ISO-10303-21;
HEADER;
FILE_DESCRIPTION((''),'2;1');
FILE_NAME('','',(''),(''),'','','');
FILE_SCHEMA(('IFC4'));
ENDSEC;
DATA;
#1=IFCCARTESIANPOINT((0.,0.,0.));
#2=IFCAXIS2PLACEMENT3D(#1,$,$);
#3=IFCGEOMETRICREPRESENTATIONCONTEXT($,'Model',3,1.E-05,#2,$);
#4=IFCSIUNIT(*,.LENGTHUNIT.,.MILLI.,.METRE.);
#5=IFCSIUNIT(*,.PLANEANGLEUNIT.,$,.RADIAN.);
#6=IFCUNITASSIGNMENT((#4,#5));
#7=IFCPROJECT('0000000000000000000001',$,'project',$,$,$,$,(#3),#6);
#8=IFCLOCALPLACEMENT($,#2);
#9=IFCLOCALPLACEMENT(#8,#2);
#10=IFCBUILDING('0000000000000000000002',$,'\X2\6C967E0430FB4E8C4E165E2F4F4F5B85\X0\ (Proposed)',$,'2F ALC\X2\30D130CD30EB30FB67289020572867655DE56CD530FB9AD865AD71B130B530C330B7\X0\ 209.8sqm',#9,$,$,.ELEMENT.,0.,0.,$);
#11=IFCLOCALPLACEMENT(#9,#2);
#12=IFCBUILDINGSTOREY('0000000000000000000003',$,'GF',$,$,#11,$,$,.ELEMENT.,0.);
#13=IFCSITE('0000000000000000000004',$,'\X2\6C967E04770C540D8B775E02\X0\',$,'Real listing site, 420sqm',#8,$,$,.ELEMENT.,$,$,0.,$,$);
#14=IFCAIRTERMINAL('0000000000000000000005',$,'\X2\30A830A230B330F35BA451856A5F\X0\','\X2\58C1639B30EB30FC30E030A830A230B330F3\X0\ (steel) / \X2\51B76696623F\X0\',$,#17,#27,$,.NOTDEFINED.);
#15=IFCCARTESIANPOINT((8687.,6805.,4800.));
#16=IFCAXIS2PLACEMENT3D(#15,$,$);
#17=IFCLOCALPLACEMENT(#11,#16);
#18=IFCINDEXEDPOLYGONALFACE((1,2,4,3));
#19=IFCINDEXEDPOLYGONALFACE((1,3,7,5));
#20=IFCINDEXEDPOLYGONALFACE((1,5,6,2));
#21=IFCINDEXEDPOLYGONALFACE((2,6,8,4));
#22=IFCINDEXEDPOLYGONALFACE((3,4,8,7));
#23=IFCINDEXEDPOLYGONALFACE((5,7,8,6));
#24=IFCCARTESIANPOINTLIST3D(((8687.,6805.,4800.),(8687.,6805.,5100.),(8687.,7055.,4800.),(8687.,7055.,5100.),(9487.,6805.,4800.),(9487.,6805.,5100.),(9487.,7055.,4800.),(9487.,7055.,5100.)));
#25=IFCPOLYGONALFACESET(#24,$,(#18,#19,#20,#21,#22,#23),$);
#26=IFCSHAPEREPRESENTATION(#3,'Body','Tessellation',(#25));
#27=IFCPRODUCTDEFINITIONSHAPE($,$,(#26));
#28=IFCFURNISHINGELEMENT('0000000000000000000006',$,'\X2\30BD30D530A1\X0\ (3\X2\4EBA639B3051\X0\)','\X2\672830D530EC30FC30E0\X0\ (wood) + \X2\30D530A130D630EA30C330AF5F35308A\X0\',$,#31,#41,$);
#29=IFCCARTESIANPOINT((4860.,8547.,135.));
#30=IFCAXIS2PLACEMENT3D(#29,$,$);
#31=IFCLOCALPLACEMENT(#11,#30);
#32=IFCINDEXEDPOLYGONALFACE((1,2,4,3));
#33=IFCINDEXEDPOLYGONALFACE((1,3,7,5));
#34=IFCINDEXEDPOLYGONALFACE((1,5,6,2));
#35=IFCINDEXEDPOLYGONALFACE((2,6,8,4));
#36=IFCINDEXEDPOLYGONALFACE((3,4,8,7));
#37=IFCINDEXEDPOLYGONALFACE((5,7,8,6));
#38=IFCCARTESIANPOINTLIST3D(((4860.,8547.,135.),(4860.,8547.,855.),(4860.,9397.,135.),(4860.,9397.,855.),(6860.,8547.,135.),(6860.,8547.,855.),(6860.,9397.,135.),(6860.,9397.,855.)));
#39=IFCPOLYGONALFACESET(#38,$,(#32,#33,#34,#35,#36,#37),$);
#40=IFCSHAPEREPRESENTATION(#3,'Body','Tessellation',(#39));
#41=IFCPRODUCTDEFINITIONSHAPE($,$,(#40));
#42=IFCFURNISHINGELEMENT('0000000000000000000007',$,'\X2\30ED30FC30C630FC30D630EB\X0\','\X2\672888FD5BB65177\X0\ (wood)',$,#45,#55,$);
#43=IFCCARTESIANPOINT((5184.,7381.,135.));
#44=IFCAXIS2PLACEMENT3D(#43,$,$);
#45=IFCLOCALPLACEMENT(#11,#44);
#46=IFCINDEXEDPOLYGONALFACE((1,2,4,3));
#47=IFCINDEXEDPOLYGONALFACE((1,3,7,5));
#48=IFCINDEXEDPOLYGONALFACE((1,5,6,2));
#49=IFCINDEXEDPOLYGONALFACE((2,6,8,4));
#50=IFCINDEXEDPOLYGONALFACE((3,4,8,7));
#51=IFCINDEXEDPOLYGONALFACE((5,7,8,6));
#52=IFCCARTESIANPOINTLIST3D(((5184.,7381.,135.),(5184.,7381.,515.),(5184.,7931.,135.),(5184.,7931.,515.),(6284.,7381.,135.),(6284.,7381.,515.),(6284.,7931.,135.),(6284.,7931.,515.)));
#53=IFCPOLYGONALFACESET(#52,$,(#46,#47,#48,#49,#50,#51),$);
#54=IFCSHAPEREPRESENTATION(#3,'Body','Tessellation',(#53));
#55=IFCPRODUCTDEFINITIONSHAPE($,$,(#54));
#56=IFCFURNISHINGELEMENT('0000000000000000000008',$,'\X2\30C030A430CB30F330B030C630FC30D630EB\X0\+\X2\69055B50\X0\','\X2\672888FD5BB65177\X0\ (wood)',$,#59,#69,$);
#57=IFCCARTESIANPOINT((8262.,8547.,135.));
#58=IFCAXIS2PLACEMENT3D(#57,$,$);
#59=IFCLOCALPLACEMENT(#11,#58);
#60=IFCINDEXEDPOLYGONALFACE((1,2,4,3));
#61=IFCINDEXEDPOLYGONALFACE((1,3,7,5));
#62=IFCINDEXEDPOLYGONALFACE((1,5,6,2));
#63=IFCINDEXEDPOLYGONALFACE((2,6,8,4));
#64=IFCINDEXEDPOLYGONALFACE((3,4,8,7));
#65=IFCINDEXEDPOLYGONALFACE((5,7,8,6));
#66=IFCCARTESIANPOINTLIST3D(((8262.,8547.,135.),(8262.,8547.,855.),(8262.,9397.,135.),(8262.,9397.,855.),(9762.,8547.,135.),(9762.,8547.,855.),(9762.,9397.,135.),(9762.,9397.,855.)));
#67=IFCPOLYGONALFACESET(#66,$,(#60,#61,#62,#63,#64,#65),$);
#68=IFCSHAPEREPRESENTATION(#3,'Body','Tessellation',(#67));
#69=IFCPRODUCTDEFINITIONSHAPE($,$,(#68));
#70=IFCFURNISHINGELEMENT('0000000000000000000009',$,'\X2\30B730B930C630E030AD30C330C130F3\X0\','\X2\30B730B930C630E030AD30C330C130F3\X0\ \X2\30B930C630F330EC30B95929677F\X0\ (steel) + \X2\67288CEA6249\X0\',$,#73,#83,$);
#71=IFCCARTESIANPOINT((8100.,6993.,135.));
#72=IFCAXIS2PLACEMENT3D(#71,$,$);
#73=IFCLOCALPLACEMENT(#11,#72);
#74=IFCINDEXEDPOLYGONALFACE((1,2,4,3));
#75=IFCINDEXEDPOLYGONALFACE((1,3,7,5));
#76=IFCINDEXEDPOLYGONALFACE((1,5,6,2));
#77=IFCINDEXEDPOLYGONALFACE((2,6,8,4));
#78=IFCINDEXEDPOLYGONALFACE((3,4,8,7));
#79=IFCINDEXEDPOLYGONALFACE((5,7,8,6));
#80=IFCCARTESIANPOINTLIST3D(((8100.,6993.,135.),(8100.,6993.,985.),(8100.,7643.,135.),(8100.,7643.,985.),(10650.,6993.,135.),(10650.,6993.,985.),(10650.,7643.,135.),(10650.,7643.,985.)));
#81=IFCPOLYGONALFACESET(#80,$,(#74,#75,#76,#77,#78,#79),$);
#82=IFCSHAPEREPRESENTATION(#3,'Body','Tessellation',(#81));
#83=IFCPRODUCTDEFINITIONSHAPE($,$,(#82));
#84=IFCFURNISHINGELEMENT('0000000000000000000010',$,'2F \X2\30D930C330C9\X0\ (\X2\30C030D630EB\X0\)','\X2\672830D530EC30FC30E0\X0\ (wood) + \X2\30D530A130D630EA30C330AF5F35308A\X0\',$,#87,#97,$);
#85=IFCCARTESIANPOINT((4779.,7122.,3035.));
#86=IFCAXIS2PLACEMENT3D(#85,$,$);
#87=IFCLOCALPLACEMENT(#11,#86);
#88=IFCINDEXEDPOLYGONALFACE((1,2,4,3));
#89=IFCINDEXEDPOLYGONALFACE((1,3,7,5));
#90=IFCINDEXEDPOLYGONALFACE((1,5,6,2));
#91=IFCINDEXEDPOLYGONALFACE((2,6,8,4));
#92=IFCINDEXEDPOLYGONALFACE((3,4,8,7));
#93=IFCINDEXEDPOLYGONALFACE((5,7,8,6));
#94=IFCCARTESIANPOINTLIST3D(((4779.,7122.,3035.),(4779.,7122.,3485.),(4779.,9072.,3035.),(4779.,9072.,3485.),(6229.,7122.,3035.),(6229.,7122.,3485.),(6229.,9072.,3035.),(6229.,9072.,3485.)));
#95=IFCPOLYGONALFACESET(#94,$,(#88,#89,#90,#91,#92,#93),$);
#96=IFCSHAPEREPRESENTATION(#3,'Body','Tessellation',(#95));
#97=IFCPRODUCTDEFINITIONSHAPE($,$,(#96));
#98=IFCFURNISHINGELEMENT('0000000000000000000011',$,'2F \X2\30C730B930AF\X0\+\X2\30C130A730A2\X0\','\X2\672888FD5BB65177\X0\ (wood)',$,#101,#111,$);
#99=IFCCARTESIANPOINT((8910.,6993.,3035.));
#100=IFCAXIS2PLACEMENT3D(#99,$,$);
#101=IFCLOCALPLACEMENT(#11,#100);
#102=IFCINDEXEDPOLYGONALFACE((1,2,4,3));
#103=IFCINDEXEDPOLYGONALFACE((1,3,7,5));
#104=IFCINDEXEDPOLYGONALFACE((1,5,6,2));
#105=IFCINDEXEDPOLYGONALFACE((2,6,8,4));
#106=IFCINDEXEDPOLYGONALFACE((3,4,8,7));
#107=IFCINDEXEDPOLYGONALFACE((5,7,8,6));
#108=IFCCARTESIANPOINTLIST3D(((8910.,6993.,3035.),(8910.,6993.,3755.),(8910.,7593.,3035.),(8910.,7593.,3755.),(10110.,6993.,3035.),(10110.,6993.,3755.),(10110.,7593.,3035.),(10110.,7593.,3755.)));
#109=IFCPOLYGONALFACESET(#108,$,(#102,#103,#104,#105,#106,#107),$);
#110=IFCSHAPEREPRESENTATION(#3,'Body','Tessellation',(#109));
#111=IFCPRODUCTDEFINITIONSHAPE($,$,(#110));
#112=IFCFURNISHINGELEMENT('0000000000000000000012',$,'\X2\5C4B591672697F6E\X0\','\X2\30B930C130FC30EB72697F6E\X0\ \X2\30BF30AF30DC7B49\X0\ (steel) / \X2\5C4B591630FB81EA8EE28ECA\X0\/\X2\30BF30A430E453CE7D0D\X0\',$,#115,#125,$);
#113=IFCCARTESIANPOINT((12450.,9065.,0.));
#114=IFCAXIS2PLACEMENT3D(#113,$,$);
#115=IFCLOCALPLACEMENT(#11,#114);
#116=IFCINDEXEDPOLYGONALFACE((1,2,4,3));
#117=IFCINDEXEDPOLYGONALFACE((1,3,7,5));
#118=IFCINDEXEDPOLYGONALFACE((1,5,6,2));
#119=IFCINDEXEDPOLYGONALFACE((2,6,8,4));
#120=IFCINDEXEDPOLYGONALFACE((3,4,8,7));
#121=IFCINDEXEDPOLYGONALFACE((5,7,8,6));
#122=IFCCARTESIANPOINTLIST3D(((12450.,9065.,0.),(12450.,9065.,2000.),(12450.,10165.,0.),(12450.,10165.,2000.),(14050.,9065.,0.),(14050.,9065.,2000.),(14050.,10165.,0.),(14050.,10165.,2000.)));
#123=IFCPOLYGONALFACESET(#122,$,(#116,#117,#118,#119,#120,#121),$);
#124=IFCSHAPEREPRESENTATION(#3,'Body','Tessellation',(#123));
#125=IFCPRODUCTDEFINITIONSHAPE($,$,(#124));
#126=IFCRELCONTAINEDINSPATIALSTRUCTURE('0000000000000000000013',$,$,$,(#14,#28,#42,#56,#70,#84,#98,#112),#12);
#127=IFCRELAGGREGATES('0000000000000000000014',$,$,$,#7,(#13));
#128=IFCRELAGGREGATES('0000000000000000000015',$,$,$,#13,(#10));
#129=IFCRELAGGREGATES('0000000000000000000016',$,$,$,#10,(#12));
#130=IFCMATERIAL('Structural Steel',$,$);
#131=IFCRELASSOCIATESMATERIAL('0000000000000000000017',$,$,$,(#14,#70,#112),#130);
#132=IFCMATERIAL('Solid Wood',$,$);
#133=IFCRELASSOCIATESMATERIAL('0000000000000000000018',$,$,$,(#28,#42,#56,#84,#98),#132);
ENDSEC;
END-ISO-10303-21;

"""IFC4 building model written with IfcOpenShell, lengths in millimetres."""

from ifc_helpers import new_model, si_unit, frame, frame_2d, origin, place, context, project, spatial, rectangle, extrude, material, element, save


model = new_model("IFC4")

# Units and contexts
model_context = context("Model", 3, precision=1e-05, world=origin())
ifc_project = project(units=[si_unit("LENGTHUNIT", "METRE", prefix="MILLI"), si_unit("PLANEANGLEUNIT", "RADIAN")], contexts=[model_context])

# Site, building, storey
site_placement = place(None, origin())
site = spatial("IfcSite", under=ifc_project, at=site_placement, Name="沖縄県名護市", ObjectType="Real listing site, 420sqm", CompositionType="ELEMENT", RefElevation=0.0)
building_placement = place(site_placement, origin())
building = spatial("IfcBuilding", under=site, at=building_placement, Name="沖縄・二世帯住宅 (Proposed)", ObjectType="2F ALCパネル・木造在来工法・高断熱サッシ 209.8sqm", CompositionType="ELEMENT", ElevationOfRefHeight=0.0, ElevationOfTerrain=0.0)
storey_placement = place(building_placement, origin())
storey = spatial("IfcBuildingStorey", under=building, at=storey_placement, Name="GF", CompositionType="ELEMENT", Elevation=0.0)

# Shared definitions
ifc_material_1 = material(Name="Solid Wood")

# Shared definitions
ifc_material_2 = material(Name="Structural Steel")

# Air terminal
air_terminal_1_placement = place(storey_placement, frame((8687.0, 6805.0, 4800.0)))
element("IfcAirTerminal", 1, at=air_terminal_1_placement, inside=storey, material=ifc_material_2, Name="エアコン室内機", Description="壁掛ルームエアコン (steel) / 冷暖房", PredefinedType="NOTDEFINED", context=model_context, shape_type="SweptSolid", body=[
    extrude(rectangle(XDim=800.0, YDim=250.0, at=frame_2d((400.0, 125.0))), frame((8687.0, 6805.0, 4800.0)), (0.0, 0.0, 1.0), 300.0),
])

# Furnishing elements
furnishing_1_placement = place(storey_placement, frame((4860.0, 8547.0, 135.0)))
element("IfcFurnishingElement", 2, at=furnishing_1_placement, inside=storey, material=ifc_material_1, Name="ソファ (3人掛け)", Description="木フレーム (wood) + ファブリック張り", context=model_context, shape_type="SweptSolid", body=[
    extrude(rectangle(XDim=2000.0, YDim=850.0, at=frame_2d((1000.0, 425.0))), frame((4860.0, 8547.0, 135.0)), (0.0, 0.0, 1.0), 720.0),
])
furnishing_2_placement = place(storey_placement, frame((5184.0, 7381.0, 135.0)))
element("IfcFurnishingElement", 3, at=furnishing_2_placement, inside=storey, material=ifc_material_1, Name="ローテーブル", Description="木製家具 (wood)", context=model_context, shape_type="SweptSolid", body=[
    extrude(rectangle(XDim=1100.0, YDim=550.0, at=frame_2d((550.0, 275.0))), frame((5184.0, 7381.0, 135.0)), (0.0, 0.0, 1.0), 380.0),
])
furnishing_3_placement = place(storey_placement, frame((8262.0, 8547.0, 135.0)))
element("IfcFurnishingElement", 4, at=furnishing_3_placement, inside=storey, material=ifc_material_1, Name="ダイニングテーブル+椅子", Description="木製家具 (wood)", context=model_context, shape_type="SweptSolid", body=[
    extrude(rectangle(XDim=1500.0, YDim=850.0, at=frame_2d((750.0, 425.0))), frame((8262.0, 8547.0, 135.0)), (0.0, 0.0, 1.0), 720.0),
])
furnishing_4_placement = place(storey_placement, frame((8100.0, 6993.0, 135.0)))
element("IfcFurnishingElement", 5, at=furnishing_4_placement, inside=storey, material=ifc_material_2, Name="システムキッチン", Description="システムキッチン ステンレス天板 (steel) + 木質扉", context=model_context, shape_type="SweptSolid", body=[
    extrude(rectangle(XDim=2550.0, YDim=650.0, at=frame_2d((1275.0, 325.0))), frame((8100.0, 6993.0, 135.0)), (0.0, 0.0, 1.0), 850.0),
])
furnishing_5_placement = place(storey_placement, frame((4779.0, 7122.0, 3035.0)))
element("IfcFurnishingElement", 6, at=furnishing_5_placement, inside=storey, material=ifc_material_1, Name="2F ベッド (ダブル)", Description="木フレーム (wood) + ファブリック張り", context=model_context, shape_type="SweptSolid", body=[
    extrude(rectangle(XDim=1450.0, YDim=1950.0, at=frame_2d((725.0, 975.0))), frame((4779.0, 7122.0, 3035.0)), (0.0, 0.0, 1.0), 450.0),
])
furnishing_6_placement = place(storey_placement, frame((8910.0, 6993.0, 3035.0)))
element("IfcFurnishingElement", 7, at=furnishing_6_placement, inside=storey, material=ifc_material_1, Name="2F デスク+チェア", Description="木製家具 (wood)", context=model_context, shape_type="SweptSolid", body=[
    extrude(rectangle(XDim=1200.0, YDim=600.0, at=frame_2d((600.0, 300.0))), frame((8910.0, 6993.0, 3035.0)), (0.0, 0.0, 1.0), 720.0),
])
furnishing_7_placement = place(storey_placement, frame((12450.0, 9065.0, 0.0)))
element("IfcFurnishingElement", 8, at=furnishing_7_placement, inside=storey, material=ifc_material_2, Name="屋外物置", Description="スチール物置 タクボ等 (steel) / 屋外・自転車/タイヤ収納", context=model_context, shape_type="SweptSolid", body=[
    extrude(rectangle(XDim=1600.0, YDim=1100.0, at=frame_2d((800.0, 550.0))), frame((12450.0, 9065.0, 0.0)), (0.0, 0.0, 1.0), 2000.0),
])

save(model, "model.ifc")
